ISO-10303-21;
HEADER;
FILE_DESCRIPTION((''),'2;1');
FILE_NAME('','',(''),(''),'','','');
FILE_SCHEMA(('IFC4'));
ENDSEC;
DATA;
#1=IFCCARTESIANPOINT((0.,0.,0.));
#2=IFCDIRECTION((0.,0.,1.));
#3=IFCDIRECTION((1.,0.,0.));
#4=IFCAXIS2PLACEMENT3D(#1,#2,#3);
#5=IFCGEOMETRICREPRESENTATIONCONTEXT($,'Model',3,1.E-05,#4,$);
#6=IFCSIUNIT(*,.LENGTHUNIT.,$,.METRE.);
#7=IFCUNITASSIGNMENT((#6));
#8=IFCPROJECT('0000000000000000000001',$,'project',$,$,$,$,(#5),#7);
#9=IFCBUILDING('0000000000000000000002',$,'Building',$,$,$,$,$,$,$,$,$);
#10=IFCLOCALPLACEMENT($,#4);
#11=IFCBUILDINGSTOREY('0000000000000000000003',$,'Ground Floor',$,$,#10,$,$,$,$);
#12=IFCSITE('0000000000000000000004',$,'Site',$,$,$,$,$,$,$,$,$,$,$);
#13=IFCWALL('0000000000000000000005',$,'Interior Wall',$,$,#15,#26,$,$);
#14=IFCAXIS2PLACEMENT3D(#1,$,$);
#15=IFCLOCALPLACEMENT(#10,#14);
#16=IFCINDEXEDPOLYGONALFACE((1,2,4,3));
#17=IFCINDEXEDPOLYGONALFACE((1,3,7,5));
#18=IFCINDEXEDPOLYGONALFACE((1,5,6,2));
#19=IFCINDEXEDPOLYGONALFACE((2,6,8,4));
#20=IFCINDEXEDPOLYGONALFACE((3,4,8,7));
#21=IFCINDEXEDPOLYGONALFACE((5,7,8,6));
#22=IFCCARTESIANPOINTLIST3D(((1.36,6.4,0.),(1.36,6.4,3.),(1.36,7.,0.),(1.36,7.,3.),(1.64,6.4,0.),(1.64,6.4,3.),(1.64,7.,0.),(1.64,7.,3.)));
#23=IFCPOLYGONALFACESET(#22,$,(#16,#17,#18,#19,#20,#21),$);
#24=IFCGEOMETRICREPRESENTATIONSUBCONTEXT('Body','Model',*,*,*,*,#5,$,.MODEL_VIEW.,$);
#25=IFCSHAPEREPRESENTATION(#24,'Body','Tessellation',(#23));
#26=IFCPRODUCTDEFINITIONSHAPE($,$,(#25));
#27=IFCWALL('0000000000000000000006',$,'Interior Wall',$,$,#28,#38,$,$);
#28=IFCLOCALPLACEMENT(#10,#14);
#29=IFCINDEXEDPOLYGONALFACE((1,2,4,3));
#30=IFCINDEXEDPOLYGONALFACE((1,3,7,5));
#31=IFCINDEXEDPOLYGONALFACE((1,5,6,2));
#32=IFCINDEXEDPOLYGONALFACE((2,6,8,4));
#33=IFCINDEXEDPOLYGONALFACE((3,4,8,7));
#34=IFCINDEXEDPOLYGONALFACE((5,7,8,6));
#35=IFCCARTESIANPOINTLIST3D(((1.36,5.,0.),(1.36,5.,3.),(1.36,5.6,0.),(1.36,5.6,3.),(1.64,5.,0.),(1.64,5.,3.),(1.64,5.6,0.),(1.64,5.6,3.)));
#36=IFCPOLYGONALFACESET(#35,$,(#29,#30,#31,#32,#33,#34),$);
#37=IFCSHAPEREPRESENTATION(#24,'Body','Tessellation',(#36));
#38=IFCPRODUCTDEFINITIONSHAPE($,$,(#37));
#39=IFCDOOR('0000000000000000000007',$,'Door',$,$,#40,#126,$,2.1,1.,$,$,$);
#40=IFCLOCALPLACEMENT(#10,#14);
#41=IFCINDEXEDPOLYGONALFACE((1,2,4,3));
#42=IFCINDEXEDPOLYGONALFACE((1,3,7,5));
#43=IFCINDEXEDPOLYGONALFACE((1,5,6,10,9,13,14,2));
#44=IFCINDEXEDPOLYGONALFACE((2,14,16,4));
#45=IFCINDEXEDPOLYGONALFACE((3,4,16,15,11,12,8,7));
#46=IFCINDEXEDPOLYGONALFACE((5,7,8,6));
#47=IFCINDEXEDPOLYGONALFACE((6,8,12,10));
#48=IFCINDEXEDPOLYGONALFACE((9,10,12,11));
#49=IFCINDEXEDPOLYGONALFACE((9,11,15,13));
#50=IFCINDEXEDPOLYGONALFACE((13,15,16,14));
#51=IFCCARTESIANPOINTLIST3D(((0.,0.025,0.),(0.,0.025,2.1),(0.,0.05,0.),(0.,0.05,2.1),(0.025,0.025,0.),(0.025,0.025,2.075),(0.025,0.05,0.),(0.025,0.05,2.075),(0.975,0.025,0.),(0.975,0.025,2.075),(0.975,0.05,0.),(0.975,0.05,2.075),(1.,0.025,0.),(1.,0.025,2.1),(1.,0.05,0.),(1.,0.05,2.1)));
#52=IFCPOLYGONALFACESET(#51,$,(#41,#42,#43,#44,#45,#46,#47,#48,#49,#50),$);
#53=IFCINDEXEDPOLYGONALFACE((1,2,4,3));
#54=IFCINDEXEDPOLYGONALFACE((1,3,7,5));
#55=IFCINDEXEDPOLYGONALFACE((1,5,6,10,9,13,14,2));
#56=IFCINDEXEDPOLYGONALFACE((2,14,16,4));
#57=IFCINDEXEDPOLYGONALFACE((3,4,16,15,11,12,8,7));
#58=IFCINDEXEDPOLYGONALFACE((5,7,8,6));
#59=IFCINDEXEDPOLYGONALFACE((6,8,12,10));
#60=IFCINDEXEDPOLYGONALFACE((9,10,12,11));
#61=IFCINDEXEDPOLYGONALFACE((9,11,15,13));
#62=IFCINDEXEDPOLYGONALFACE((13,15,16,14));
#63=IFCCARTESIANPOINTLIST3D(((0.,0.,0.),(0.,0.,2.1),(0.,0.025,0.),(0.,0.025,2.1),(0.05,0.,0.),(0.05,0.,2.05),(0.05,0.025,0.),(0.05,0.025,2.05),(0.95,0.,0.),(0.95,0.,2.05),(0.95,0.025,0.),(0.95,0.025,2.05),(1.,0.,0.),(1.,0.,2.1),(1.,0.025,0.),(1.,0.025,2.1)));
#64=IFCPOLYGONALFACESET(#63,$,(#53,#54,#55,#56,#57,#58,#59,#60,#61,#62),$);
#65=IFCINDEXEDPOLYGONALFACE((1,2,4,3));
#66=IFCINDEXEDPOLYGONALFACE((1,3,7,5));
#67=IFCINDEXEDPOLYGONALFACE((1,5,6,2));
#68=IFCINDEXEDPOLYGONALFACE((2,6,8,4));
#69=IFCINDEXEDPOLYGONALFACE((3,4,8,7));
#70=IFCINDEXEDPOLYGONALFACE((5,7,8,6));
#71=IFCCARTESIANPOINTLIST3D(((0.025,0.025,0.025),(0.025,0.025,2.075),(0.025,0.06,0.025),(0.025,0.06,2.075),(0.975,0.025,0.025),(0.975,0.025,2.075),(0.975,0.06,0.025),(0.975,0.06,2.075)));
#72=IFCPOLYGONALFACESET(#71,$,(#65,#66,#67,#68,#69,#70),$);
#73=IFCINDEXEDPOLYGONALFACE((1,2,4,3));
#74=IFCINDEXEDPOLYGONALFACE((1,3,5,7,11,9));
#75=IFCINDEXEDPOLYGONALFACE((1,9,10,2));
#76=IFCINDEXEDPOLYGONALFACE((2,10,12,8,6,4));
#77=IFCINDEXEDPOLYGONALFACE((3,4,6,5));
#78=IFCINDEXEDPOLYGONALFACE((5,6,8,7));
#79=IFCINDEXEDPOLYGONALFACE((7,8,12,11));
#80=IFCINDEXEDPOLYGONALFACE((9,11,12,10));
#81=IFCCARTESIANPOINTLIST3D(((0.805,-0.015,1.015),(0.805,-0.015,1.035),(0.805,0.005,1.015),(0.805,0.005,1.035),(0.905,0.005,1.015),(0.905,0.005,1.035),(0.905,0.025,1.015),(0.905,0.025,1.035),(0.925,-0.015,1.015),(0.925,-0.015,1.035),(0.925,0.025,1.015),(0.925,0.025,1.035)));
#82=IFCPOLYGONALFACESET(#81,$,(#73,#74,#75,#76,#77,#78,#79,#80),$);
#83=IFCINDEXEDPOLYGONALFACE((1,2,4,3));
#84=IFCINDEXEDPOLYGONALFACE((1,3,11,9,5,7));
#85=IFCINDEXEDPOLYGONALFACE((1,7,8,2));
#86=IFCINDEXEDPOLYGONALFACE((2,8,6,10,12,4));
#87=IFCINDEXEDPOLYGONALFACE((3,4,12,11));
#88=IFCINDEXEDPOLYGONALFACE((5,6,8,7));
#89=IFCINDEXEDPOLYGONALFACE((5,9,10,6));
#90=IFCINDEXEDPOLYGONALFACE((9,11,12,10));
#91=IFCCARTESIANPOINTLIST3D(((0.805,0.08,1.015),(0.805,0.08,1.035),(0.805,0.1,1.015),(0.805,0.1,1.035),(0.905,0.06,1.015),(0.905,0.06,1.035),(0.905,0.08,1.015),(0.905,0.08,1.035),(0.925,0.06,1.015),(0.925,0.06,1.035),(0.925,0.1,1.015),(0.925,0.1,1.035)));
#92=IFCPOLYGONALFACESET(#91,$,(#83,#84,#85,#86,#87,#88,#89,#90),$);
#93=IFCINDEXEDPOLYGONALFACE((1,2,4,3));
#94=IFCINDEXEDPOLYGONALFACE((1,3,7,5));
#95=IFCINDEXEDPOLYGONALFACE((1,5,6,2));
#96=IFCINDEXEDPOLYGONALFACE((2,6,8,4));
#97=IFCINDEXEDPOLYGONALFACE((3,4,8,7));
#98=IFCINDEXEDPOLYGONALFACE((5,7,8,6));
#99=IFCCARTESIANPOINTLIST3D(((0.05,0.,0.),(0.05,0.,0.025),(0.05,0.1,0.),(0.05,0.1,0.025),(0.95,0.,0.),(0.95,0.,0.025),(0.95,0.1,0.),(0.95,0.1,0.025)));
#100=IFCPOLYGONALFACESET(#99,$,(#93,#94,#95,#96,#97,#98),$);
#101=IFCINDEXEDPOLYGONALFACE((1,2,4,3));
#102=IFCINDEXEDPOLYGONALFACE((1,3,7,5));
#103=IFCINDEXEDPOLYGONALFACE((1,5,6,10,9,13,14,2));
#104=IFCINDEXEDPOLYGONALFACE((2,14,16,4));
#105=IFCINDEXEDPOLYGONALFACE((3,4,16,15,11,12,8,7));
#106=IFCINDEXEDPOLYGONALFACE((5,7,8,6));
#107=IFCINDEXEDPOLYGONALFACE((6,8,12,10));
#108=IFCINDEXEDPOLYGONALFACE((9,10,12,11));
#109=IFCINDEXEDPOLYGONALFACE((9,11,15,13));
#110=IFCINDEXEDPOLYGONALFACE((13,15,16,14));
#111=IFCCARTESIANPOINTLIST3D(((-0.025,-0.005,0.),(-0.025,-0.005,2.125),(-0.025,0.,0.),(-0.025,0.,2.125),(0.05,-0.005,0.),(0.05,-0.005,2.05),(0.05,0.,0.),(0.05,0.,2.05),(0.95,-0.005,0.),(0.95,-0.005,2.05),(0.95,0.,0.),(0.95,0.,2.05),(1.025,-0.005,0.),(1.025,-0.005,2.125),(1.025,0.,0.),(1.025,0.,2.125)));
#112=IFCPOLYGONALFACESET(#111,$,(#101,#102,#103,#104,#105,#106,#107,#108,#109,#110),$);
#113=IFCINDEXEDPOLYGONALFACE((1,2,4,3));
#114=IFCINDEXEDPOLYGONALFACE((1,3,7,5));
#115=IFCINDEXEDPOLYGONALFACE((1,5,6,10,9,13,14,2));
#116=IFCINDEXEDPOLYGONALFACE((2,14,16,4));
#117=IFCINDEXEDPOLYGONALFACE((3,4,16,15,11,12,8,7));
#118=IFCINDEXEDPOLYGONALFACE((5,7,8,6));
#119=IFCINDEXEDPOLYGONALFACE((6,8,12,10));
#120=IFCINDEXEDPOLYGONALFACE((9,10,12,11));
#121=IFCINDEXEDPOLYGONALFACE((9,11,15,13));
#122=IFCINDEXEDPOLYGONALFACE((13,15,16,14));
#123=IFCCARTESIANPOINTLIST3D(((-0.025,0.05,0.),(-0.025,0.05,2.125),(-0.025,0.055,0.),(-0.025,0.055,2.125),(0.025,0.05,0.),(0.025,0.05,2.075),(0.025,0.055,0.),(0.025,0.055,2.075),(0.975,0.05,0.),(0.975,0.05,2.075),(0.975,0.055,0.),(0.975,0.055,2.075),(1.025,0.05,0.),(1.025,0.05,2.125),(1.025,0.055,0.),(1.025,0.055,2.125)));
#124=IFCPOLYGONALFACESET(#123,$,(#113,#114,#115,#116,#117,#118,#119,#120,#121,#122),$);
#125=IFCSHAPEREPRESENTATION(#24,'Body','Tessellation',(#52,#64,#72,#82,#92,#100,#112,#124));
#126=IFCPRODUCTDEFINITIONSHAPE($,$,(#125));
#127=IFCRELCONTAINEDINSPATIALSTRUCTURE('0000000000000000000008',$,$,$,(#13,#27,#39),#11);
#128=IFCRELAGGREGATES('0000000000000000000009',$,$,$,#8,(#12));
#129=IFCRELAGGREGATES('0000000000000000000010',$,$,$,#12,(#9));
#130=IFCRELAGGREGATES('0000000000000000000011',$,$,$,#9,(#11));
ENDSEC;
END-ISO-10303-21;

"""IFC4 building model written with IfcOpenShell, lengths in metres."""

from ifc_helpers import new_model, si_unit, frame, origin_with_axes, place, context, subcontext, project, spatial, line, indexed_curve, outline, extrude, element, save


model = new_model("IFC4")

# Units and contexts
model_context = context("Model", 3, precision=1e-05, world=origin_with_axes())
body_context = subcontext(model_context, "Body", "Model", "MODEL_VIEW")
ifc_project = project(units=[si_unit("LENGTHUNIT", "METRE")], contexts=[model_context])

# Site, building, storey
site = spatial("IfcSite", under=ifc_project, Name="Site")
building = spatial("IfcBuilding", under=site, Name="Building")
storey_placement = place(None, origin_with_axes())
storey = spatial("IfcBuildingStorey", under=building, at=storey_placement, Name="Ground Floor")

# Walls
for number, where, z_axis, x_axis, name in (
    (1, (1.5, 7.0, 0.0), (0.0, 0.0, 1.0), (0.0, -1.0, 0.0), "Interior Wall"),
    (2, (1.5, 5.6, 0.0), (0.0, 0.0, 1.0), (0.0, -1.0, 0.0), "Interior Wall"),
):
    element("IfcWall", number, at=place(storey_placement, frame(where, z_axis=z_axis, x_axis=x_axis)), inside=storey, Name=name, context=body_context, shape_type="SweptSolid", body=[
        extrude(outline(indexed_curve([(0.0, 0.0), (0.0, 0.28), (0.6, 0.28), (0.6, 0.0), (0.0, 0.0)], self_intersect=False)), frame((0.0, -0.14, 0.0), z_axis=(0.0, 0.0, 1.0), x_axis=(1.0, 0.0, 0.0)), (0.0, 0.0, 1.0), 3.0),
    ])

# Door
door_1_placement = place(storey_placement, origin_with_axes())
element("IfcDoor", 3, at=door_1_placement, inside=storey, Name="Door", OverallHeight=2.1, OverallWidth=1.0, context=body_context, shape_type="SweptSolid", body=[
    extrude(outline(indexed_curve([(0.0, 0.0), (0.0, 2.1), (1.0, 2.1), (1.0, 0.0), (0.975, 0.0), (0.975, 2.075), (0.025, 2.075), (0.025, 0.0)], segments=[line(1, 2, 3, 4, 5, 6, 7, 8, 1)])), frame((0.0, 0.025, 0.0), z_axis=(0.0, -1.0, 0.0), x_axis=(1.0, 0.0, 0.0)), (0.0, 0.0, -1.0), 0.025),
    extrude(outline(indexed_curve([(0.0, 0.0), (0.0, 2.1), (1.0, 2.1), (1.0, 0.0), (0.95, 0.0), (0.95, 2.05), (0.05, 2.05), (0.05, 0.0)], segments=[line(1, 2, 3, 4, 5, 6, 7, 8, 1)])), frame((0.0, 0.0, 0.0), z_axis=(0.0, -1.0, 0.0), x_axis=(1.0, 0.0, 0.0)), (0.0, 0.0, -1.0), 0.025),
    extrude(outline(indexed_curve([(0.0, 0.0), (0.95, 0.0), (0.95, 0.035), (0.0, 0.035)], segments=[line(1, 2, 3, 4, 1)])), frame((0.025, 0.025, 0.025), z_axis=(0.0, 0.0, 1.0), x_axis=(1.0, 0.0, 0.0)), (0.0, 0.0, 1.0), 2.05),
    extrude(outline(indexed_curve([(0.0, 0.0), (0.0, -0.04), (-0.12, -0.04), (-0.12, -0.02), (-0.02, -0.02), (-0.02, 0.0)], segments=[line(1, 2, 3, 4, 5, 6, 1)])), frame((0.925, 0.025, 1.015), z_axis=(0.0, 0.0, 1.0), x_axis=(1.0, 0.0, 0.0)), (0.0, 0.0, 1.0), 0.02),
    extrude(outline(indexed_curve([(0.0, 0.0), (0.0, 0.04), (-0.12, 0.04), (-0.12, 0.02), (-0.02, 0.02), (-0.02, 0.0)], segments=[line(1, 2, 3, 4, 5, 6, 1)])), frame((0.925, 0.06, 1.015), z_axis=(0.0, 0.0, 1.0), x_axis=(1.0, 0.0, 0.0)), (0.0, 0.0, 1.0), 0.02),
    extrude(outline(indexed_curve([(0.0, 0.0), (0.9, 0.0), (0.9, 0.1), (0.0, 0.1)], segments=[line(1, 2, 3, 4, 1)])), frame((0.05, 0.0, 0.0), z_axis=(0.0, 0.0, 1.0), x_axis=(1.0, 0.0, 0.0)), (0.0, 0.0, 1.0), 0.025),
    extrude(outline(indexed_curve([(0.0, 0.0), (0.0, 2.125), (1.05, 2.125), (1.05, 0.0), (0.975, 0.0), (0.975, 2.05), (0.075, 2.05), (0.075, 0.0)], segments=[line(1, 2, 3, 4, 5, 6, 7, 8, 1)])), frame((-0.025, -0.005, 0.0), z_axis=(0.0, -1.0, 0.0), x_axis=(1.0, 0.0, 0.0)), (0.0, 0.0, -1.0), 0.005),
    extrude(outline(indexed_curve([(0.0, 0.0), (0.0, 2.125), (1.05, 2.125), (1.05, 0.0), (1.0, 0.0), (1.0, 2.075), (0.05, 2.075), (0.05, 0.0)], segments=[line(1, 2, 3, 4, 5, 6, 7, 8, 1)])), frame((-0.025, 0.05, 0.0), z_axis=(0.0, -1.0, 0.0), x_axis=(1.0, 0.0, 0.0)), (0.0, 0.0, -1.0), 0.005),
])

save(model, "model.ifc")
